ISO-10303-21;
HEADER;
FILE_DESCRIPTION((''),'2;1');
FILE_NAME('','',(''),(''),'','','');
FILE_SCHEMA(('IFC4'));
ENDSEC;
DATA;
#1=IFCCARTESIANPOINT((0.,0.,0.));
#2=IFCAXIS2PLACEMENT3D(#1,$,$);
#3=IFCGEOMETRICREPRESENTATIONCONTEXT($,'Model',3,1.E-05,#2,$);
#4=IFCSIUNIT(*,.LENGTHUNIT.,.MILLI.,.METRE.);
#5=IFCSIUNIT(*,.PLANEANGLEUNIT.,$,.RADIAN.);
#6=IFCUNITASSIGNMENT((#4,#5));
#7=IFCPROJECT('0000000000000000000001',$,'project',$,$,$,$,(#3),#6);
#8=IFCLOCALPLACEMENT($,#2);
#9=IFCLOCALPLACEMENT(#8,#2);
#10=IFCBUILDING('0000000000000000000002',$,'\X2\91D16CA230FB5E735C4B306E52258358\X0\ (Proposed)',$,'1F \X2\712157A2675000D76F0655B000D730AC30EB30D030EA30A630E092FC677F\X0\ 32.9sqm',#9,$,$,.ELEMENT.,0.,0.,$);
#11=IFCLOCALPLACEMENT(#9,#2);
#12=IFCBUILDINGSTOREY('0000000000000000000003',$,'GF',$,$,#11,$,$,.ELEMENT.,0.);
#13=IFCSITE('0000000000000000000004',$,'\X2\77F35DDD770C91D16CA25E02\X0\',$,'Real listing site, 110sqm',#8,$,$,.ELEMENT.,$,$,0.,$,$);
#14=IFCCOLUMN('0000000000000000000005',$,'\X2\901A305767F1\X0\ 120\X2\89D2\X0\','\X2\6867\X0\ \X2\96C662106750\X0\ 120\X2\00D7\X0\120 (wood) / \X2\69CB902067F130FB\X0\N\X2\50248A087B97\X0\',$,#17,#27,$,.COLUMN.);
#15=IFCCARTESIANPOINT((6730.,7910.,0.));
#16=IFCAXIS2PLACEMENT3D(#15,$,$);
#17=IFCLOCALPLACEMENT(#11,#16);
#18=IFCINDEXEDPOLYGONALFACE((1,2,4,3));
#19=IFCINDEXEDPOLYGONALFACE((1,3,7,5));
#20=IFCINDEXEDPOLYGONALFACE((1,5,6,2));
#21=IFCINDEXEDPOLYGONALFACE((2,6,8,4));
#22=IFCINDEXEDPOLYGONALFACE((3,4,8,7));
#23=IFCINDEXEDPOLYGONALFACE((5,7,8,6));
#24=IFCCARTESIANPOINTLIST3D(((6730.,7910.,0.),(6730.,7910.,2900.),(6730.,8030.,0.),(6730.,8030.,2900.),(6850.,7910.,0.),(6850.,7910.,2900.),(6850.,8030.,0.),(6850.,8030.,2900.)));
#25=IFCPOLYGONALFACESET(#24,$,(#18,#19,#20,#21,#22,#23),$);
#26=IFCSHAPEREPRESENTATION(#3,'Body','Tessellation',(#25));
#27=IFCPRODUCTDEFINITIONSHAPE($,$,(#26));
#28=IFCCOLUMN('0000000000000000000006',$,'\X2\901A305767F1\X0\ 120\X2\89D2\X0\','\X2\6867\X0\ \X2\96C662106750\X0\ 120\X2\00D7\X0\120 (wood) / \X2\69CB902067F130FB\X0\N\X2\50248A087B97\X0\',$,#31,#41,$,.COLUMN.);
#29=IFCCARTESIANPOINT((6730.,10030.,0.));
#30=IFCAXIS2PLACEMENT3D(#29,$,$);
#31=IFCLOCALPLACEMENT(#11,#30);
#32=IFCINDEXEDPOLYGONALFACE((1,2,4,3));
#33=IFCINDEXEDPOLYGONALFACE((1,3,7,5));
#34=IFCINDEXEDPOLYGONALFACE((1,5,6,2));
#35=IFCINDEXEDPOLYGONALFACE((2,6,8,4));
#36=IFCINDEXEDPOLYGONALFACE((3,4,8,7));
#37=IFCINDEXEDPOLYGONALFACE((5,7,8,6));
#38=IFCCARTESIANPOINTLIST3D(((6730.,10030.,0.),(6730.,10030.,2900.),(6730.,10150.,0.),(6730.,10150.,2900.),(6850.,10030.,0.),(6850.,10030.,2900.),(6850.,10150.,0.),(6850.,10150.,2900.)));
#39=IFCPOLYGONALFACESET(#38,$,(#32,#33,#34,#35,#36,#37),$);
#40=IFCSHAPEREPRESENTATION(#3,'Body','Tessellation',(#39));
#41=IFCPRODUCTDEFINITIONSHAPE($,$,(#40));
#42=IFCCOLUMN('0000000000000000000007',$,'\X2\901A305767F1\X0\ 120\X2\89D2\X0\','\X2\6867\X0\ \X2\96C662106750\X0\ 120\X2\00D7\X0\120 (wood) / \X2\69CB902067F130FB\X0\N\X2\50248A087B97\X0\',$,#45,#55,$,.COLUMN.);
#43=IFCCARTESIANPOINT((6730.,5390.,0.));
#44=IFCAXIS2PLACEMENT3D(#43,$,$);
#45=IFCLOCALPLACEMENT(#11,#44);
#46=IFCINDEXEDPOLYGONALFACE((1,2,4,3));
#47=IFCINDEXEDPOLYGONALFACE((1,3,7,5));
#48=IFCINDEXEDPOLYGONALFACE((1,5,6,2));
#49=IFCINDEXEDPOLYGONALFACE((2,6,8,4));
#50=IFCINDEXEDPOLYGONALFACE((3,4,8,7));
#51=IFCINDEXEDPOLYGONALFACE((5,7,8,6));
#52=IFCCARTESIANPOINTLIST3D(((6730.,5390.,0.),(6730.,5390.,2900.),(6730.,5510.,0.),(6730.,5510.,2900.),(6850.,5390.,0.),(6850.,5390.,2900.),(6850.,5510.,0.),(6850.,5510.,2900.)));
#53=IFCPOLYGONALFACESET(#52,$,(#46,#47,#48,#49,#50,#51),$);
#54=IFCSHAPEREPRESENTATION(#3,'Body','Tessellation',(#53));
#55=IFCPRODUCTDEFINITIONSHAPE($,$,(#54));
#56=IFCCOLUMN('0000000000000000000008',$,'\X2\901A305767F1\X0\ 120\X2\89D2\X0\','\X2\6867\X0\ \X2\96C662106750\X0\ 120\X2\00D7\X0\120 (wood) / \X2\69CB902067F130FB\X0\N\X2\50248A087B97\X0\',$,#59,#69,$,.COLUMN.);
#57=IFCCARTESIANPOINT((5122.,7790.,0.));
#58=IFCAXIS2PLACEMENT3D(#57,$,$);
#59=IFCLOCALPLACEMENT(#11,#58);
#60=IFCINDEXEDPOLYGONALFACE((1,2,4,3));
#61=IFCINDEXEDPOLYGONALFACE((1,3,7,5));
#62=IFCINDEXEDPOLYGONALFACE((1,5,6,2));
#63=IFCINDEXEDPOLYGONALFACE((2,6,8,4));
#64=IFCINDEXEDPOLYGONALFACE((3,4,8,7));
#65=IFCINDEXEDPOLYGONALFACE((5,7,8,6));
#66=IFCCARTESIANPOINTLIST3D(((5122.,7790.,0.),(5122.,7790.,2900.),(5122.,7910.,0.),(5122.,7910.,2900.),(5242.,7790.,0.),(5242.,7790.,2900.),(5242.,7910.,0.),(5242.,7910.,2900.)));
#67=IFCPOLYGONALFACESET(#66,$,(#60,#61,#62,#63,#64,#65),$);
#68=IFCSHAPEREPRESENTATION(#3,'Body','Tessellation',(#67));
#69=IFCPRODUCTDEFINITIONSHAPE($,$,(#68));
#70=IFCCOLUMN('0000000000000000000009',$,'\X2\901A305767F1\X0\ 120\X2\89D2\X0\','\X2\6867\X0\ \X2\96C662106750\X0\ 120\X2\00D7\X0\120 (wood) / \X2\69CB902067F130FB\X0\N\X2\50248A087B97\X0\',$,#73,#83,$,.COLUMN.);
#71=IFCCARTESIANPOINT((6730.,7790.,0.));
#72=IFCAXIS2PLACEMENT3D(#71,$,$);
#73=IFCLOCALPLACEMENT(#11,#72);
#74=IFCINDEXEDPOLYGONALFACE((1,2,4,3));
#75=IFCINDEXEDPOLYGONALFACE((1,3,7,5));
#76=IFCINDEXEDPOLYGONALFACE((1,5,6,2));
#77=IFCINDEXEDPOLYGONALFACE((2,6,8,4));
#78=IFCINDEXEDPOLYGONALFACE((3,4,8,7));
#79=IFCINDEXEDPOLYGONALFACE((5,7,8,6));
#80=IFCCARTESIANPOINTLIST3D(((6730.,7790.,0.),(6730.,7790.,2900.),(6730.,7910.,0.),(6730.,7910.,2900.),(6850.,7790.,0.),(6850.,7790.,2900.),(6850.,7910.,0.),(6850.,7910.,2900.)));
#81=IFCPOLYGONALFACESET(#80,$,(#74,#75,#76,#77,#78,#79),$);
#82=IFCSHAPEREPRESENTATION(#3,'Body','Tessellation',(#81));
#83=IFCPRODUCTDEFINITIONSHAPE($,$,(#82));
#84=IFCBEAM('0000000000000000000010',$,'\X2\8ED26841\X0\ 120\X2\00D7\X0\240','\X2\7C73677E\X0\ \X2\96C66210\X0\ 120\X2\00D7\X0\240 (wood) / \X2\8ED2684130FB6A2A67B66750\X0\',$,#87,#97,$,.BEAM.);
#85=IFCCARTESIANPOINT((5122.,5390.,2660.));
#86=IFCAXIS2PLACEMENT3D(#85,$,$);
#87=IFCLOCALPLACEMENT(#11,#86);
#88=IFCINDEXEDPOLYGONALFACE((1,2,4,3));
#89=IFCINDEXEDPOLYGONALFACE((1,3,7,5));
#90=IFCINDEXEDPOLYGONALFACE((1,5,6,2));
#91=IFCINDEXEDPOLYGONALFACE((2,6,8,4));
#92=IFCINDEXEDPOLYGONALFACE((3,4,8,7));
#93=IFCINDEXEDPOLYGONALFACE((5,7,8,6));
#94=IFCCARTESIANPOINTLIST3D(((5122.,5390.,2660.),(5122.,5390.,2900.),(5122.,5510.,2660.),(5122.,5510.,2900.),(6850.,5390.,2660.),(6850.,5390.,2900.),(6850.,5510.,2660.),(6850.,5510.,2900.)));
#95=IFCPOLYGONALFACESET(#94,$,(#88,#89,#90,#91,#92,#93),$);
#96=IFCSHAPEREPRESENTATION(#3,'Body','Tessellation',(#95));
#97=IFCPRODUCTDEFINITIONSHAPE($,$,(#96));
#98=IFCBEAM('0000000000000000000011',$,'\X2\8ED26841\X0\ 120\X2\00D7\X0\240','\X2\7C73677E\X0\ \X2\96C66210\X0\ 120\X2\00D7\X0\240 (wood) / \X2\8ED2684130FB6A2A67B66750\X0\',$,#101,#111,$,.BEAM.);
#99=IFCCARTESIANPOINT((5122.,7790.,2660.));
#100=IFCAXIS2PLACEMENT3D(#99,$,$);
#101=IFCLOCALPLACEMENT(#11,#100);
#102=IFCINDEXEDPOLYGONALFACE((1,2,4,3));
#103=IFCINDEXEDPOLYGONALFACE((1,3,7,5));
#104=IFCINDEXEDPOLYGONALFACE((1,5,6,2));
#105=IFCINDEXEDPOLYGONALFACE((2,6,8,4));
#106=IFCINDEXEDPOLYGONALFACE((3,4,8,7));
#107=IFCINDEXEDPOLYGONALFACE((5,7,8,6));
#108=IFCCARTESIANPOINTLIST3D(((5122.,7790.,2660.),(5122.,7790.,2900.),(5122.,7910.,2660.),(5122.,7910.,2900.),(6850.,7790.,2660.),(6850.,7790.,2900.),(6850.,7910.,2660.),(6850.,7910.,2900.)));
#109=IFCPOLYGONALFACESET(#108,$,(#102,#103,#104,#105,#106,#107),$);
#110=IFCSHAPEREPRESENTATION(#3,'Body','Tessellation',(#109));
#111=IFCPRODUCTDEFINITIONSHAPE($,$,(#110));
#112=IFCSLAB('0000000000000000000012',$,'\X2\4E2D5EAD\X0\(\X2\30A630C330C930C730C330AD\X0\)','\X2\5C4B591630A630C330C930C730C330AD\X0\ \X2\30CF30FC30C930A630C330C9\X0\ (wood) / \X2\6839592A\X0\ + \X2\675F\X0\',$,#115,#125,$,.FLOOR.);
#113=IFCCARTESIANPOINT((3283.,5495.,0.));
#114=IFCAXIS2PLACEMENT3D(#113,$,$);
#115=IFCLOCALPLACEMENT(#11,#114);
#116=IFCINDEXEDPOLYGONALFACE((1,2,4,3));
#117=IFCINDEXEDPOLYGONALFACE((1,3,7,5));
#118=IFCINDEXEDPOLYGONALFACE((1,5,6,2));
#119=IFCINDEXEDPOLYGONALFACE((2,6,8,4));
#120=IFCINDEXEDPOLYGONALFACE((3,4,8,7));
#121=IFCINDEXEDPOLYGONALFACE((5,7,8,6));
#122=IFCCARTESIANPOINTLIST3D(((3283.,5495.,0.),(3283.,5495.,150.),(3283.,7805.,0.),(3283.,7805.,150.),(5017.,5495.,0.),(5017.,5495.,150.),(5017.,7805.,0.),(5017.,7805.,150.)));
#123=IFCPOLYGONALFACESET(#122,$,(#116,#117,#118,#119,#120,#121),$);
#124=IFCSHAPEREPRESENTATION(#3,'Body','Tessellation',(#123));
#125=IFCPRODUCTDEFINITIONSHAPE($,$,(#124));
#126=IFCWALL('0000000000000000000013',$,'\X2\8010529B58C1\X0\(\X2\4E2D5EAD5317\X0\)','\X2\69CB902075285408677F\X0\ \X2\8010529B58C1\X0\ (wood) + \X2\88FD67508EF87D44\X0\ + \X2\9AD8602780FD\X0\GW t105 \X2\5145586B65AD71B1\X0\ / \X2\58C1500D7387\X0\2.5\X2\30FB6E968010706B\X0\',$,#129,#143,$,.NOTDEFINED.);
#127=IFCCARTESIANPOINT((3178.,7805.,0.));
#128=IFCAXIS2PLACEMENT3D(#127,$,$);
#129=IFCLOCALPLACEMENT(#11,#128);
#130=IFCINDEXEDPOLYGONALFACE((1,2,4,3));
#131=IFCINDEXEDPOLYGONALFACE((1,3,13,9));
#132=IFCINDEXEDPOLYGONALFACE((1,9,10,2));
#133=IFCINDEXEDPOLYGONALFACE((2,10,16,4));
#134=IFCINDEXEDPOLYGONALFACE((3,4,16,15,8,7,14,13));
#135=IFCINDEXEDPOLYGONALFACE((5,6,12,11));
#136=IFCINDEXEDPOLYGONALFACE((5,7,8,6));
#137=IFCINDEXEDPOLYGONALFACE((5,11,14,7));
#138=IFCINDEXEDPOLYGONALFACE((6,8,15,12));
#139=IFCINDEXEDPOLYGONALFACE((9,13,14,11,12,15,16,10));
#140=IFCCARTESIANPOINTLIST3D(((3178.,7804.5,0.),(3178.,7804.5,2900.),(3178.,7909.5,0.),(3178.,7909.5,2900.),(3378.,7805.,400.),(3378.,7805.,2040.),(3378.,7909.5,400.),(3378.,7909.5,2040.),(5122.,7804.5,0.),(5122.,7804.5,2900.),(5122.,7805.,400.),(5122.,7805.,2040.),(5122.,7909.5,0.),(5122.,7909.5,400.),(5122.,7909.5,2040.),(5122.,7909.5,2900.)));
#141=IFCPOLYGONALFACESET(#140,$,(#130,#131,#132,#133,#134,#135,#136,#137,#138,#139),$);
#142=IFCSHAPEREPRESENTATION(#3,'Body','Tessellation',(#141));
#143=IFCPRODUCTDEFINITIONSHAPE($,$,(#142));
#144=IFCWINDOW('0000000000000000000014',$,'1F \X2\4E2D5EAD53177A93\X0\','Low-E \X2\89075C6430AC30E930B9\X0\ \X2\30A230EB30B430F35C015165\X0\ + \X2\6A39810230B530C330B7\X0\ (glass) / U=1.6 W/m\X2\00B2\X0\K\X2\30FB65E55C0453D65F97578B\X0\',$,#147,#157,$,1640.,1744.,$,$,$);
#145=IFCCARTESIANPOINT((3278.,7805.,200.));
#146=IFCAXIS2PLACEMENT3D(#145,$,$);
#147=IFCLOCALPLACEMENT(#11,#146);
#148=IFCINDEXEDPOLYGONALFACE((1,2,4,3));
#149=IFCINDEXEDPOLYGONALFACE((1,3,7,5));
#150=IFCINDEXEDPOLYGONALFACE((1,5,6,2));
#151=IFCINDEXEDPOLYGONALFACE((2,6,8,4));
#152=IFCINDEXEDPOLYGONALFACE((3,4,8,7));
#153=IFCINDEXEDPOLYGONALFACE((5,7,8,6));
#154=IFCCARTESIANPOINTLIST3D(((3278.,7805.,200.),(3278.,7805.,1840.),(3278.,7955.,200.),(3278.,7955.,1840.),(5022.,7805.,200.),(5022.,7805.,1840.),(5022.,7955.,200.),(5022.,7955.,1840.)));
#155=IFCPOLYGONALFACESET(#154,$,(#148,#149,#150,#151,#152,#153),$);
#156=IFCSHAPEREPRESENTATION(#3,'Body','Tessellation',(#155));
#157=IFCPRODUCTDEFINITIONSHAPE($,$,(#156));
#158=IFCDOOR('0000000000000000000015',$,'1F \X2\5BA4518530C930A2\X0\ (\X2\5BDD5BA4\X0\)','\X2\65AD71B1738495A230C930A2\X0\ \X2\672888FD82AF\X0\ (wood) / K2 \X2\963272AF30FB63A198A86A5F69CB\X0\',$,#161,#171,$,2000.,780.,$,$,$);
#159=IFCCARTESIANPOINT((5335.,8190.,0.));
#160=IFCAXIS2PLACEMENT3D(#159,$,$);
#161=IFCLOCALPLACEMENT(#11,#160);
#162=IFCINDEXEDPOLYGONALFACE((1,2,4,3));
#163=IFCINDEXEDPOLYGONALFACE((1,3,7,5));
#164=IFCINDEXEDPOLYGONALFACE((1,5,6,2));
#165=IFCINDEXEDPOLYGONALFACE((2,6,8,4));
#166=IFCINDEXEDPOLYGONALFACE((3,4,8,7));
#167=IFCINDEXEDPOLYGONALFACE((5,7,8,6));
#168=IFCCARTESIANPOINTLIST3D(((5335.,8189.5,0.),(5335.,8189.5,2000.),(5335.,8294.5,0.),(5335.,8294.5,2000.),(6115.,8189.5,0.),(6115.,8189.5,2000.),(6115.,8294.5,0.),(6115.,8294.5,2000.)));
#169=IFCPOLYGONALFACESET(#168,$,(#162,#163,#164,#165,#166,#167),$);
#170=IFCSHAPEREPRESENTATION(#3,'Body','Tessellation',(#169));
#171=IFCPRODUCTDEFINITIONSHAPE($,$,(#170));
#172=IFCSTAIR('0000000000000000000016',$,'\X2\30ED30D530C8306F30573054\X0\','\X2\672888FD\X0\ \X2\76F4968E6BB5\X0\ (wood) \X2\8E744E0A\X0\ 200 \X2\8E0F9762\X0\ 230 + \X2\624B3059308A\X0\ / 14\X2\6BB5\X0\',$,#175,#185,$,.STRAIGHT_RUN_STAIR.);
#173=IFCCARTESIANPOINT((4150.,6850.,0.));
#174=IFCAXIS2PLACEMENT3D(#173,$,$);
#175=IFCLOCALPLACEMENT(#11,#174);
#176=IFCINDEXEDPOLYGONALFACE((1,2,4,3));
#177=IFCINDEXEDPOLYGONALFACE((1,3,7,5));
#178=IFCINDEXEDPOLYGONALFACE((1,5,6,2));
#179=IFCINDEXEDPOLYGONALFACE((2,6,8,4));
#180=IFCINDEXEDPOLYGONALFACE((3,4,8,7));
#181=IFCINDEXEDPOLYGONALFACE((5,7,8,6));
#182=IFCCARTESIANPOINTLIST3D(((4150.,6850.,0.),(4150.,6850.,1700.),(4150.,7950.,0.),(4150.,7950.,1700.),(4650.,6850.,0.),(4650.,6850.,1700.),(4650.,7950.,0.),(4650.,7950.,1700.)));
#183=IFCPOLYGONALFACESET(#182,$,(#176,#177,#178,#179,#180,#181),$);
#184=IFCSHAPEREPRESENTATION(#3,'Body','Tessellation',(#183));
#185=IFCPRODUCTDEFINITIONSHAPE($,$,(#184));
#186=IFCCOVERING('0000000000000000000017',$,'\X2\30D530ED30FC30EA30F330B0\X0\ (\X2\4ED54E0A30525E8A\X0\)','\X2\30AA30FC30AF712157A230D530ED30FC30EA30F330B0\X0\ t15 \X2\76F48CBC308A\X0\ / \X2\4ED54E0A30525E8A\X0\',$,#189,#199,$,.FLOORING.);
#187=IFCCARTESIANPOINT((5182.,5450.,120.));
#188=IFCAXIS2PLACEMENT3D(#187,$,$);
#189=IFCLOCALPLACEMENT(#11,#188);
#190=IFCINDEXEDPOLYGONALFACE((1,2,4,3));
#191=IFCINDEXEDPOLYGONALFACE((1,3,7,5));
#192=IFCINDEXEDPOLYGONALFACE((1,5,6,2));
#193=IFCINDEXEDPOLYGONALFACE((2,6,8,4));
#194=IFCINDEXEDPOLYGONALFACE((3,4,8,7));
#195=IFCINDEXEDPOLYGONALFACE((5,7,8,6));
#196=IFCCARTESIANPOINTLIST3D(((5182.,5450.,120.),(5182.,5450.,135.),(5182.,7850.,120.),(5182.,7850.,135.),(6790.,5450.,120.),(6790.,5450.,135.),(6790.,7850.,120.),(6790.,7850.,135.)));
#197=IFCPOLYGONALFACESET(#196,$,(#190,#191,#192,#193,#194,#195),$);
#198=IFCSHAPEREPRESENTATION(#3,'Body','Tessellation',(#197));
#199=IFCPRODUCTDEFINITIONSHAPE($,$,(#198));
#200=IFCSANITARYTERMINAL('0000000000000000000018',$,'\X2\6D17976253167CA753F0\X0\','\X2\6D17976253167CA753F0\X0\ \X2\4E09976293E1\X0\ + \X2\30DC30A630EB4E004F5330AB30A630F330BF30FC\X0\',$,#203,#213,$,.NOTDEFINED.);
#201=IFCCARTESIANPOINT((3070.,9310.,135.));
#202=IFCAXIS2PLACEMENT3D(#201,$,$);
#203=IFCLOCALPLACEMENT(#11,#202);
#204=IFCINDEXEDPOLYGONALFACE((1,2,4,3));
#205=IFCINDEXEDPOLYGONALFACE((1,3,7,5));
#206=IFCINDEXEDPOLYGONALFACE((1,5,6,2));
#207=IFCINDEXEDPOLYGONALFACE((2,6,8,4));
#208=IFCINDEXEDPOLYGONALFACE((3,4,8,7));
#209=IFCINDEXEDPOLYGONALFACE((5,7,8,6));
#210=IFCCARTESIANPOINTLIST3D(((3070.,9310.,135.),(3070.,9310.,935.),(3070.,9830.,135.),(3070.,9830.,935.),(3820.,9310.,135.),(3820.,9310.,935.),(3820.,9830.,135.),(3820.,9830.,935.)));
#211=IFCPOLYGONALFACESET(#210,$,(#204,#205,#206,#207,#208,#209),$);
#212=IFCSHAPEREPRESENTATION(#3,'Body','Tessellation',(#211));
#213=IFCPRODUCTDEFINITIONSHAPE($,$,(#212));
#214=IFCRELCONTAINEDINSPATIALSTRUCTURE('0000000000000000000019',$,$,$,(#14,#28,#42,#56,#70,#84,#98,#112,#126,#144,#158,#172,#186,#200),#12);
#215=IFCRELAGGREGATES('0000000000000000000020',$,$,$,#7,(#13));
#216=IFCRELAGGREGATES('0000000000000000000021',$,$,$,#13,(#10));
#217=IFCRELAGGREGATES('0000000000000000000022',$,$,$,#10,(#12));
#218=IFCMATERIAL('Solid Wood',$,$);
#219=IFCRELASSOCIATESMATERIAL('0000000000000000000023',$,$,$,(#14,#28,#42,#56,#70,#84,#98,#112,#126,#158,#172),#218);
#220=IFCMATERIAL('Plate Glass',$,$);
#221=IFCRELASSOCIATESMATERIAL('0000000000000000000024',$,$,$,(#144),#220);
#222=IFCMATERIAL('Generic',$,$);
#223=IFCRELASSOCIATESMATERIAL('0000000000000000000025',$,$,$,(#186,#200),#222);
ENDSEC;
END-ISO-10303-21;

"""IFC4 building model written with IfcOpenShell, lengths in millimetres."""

from ifc_helpers import new_model, si_unit, frame, frame_2d, origin, place, context, project, spatial, rectangle, extrude, material, element, fill, save


model = new_model("IFC4")

# Units and contexts
model_context = context("Model", 3, precision=1e-05, world=origin())
ifc_project = project(units=[si_unit("LENGTHUNIT", "METRE", prefix="MILLI"), si_unit("PLANEANGLEUNIT", "RADIAN")], contexts=[model_context])

# Site, building, storey
site_placement = place(None, origin())
site = spatial("IfcSite", under=ifc_project, at=site_placement, Name="石川県金沢市", ObjectType="Real listing site, 110sqm", CompositionType="ELEMENT", RefElevation=0.0)
building_placement = place(site_placement, origin())
building = spatial("IfcBuilding", under=site, at=building_placement, Name="金沢・平屋の別荘 (Proposed)", ObjectType="1F 無垢材×漆喰×ガルバリウム鋼板 32.9sqm", CompositionType="ELEMENT", ElevationOfRefHeight=0.0, ElevationOfTerrain=0.0)
storey_placement = place(building_placement, origin())
storey = spatial("IfcBuildingStorey", under=building, at=storey_placement, Name="GF", CompositionType="ELEMENT", Elevation=0.0)

# Columns
ifc_material_1 = material(Name="Solid Wood")
column_1_placement = place(storey_placement, frame((6730.0, 7910.0, 0.0)))
element("IfcColumn", 1, at=column_1_placement, inside=storey, material=ifc_material_1, Name="通し柱 120角", Description="桧 集成材 120×120 (wood) / 構造柱・N値計算", PredefinedType="COLUMN", context=model_context, shape_type="SweptSolid", body=[
    extrude(rectangle(XDim=120.0, YDim=120.0, at=frame_2d((60.0, 60.0))), frame((6730.0, 7910.0, 0.0)), (0.0, 0.0, 1.0), 2900.0),
])
column_2_placement = place(storey_placement, frame((6730.0, 10030.0, 0.0)))
element("IfcColumn", 2, at=column_2_placement, inside=storey, material=ifc_material_1, Name="通し柱 120角", Description="桧 集成材 120×120 (wood) / 構造柱・N値計算", PredefinedType="COLUMN", context=model_context, shape_type="SweptSolid", body=[
    extrude(rectangle(XDim=120.0, YDim=120.0, at=frame_2d((60.0, 60.0))), frame((6730.0, 10030.0, 0.0)), (0.0, 0.0, 1.0), 2900.0),
])
column_3_placement = place(storey_placement, frame((6730.0, 5390.0, 0.0)))
element("IfcColumn", 3, at=column_3_placement, inside=storey, material=ifc_material_1, Name="通し柱 120角", Description="桧 集成材 120×120 (wood) / 構造柱・N値計算", PredefinedType="COLUMN", context=model_context, shape_type="SweptSolid", body=[
    extrude(rectangle(XDim=120.0, YDim=120.0, at=frame_2d((60.0, 60.0))), frame((6730.0, 5390.0, 0.0)), (0.0, 0.0, 1.0), 2900.0),
])
column_4_placement = place(storey_placement, frame((5122.0, 7790.0, 0.0)))
element("IfcColumn", 4, at=column_4_placement, inside=storey, material=ifc_material_1, Name="通し柱 120角", Description="桧 集成材 120×120 (wood) / 構造柱・N値計算", PredefinedType="COLUMN", context=model_context, shape_type="SweptSolid", body=[
    extrude(rectangle(XDim=120.0, YDim=120.0, at=frame_2d((60.0, 60.0))), frame((5122.0, 7790.0, 0.0)), (0.0, 0.0, 1.0), 2900.0),
])
column_5_placement = place(storey_placement, frame((6730.0, 7790.0, 0.0)))
element("IfcColumn", 5, at=column_5_placement, inside=storey, material=ifc_material_1, Name="通し柱 120角", Description="桧 集成材 120×120 (wood) / 構造柱・N値計算", PredefinedType="COLUMN", context=model_context, shape_type="SweptSolid", body=[
    extrude(rectangle(XDim=120.0, YDim=120.0, at=frame_2d((60.0, 60.0))), frame((6730.0, 7790.0, 0.0)), (0.0, 0.0, 1.0), 2900.0),
])

# Beams
beam_1_placement = place(storey_placement, frame((5122.0, 5390.0, 2660.0)))
element("IfcBeam", 6, at=beam_1_placement, inside=storey, material=ifc_material_1, Name="軒桁 120×240", Description="米松 集成 120×240 (wood) / 軒桁・横架材", PredefinedType="BEAM", context=model_context, shape_type="SweptSolid", body=[
    extrude(rectangle(XDim=1728.0, YDim=120.0, at=frame_2d((864.0, 60.0))), frame((5122.0, 5390.0, 2660.0)), (0.0, 0.0, 1.0), 240.0),
])
beam_2_placement = place(storey_placement, frame((5122.0, 7790.0, 2660.0)))
element("IfcBeam", 7, at=beam_2_placement, inside=storey, material=ifc_material_1, Name="軒桁 120×240", Description="米松 集成 120×240 (wood) / 軒桁・横架材", PredefinedType="BEAM", context=model_context, shape_type="SweptSolid", body=[
    extrude(rectangle(XDim=1728.0, YDim=120.0, at=frame_2d((864.0, 60.0))), frame((5122.0, 7790.0, 2660.0)), (0.0, 0.0, 1.0), 240.0),
])

# Slab
slab_placement = place(storey_placement, frame((3283.0, 5495.0, 0.0)))
element("IfcSlab", 8, at=slab_placement, inside=storey, material=ifc_material_1, Name="中庭(ウッドデッキ)", Description="屋外ウッドデッキ ハードウッド (wood) / 根太 + 束", PredefinedType="FLOOR", context=model_context, shape_type="SweptSolid", body=[
    extrude(rectangle(XDim=1734.0, YDim=2310.0, at=frame_2d((867.0, 1155.0))), frame((3283.0, 5495.0, 0.0)), (0.0, 0.0, 1.0), 150.0),
])

# Wall, opening, window
wall_1_placement = place(storey_placement, frame((3178.0, 7805.0, 0.0)))
wall_1 = element("IfcWall", 9, at=wall_1_placement, inside=storey, material=ifc_material_1, Name="耐力壁(中庭北)", Description="構造用合板 耐力壁 (wood) + 製材軸組 + 高性能GW t105 充填断熱 / 壁倍率2.5・準耐火", PredefinedType="NOTDEFINED", context=model_context, shape_type="SweptSolid", body=[
    extrude(rectangle(XDim=1944.0, YDim=105.0, at=frame_2d((972.0, 52.0))), frame((3178.0, 7805.0, 0.0)), (0.0, 0.0, 1.0), 2900.0),
])
opening_placement = place(storey_placement, frame((3278.0, 7805.0, 200.0)))
opening = element("IfcOpeningElement", 10, at=opening_placement, cuts=wall_1, PredefinedType="NOTDEFINED", context=model_context, shape_type="SweptSolid", body=[
    extrude(rectangle(XDim=1744.0, YDim=150.0, at=frame_2d((872.0, 75.0))), frame((3278.0, 7805.0, 200.0)), (0.0, 0.0, 1.0), 1640.0),
])
ifc_material_2 = material(Name="Plate Glass")
window_placement = place(storey_placement, frame((3278.0, 7805.0, 200.0)))
window = element("IfcWindow", 11, at=window_placement, inside=storey, material=ifc_material_2, Name="1F 中庭北窓", Description="Low-E 複層ガラス アルゴン封入 + 樹脂サッシ (glass) / U=1.6 W/m²K・日射取得型", OverallHeight=1640.0, OverallWidth=1744.0, context=model_context, shape_type="SweptSolid", body=[
    extrude(rectangle(XDim=1744.0, YDim=150.0, at=frame_2d((872.0, 75.0))), frame((3278.0, 7805.0, 200.0)), (0.0, 0.0, 1.0), 1640.0),
])
fill(opening, window)

# Door
door_placement = place(storey_placement, frame((5335.0, 8190.0, 0.0)))
element("IfcDoor", 12, at=door_placement, inside=storey, material=ifc_material_1, Name="1F 室内ドア (寝室)", Description="断熱玄関ドア 木製芯 (wood) / K2 防犯・採風機構", OverallHeight=2000.0, OverallWidth=780.0, context=model_context, shape_type="SweptSolid", body=[
    extrude(rectangle(XDim=780.0, YDim=105.0, at=frame_2d((390.0, 52.0))), frame((5335.0, 8190.0, 0.0)), (0.0, 0.0, 1.0), 2000.0),
])

# Stair
stair_placement = place(storey_placement, frame((4150.0, 6850.0, 0.0)))
element("IfcStair", 13, at=stair_placement, inside=storey, material=ifc_material_1, Name="ロフトはしご", Description="木製 直階段 (wood) 蹴上 200 踏面 230 + 手すり / 14段", PredefinedType="STRAIGHT_RUN_STAIR", context=model_context, shape_type="SweptSolid", body=[
    extrude(rectangle(XDim=500.0, YDim=1100.0, at=frame_2d((250.0, 550.0))), frame((4150.0, 6850.0, 0.0)), (0.0, 0.0, 1.0), 1700.0),
])

# Covering
ifc_material_3 = material(Name="Generic")
covering_placement = place(storey_placement, frame((5182.0, 5450.0, 120.0)))
element("IfcCovering", 14, at=covering_placement, inside=storey, material=ifc_material_3, Name="フローリング (仕上げ床)", Description="オーク無垢フローリング t15 直貼り / 仕上げ床", PredefinedType="FLOORING", context=model_context, shape_type="SweptSolid", body=[
    extrude(rectangle(XDim=1608.0, YDim=2400.0, at=frame_2d((804.0, 1200.0))), frame((5182.0, 5450.0, 120.0)), (0.0, 0.0, 1.0), 15.0),
])

# Sanitary terminal
sanitary_terminal_1_placement = place(storey_placement, frame((3070.0, 9310.0, 135.0)))
element("IfcSanitaryTerminal", 15, at=sanitary_terminal_1_placement, inside=storey, material=ifc_material_3, Name="洗面化粧台", Description="洗面化粧台 三面鏡 + ボウル一体カウンター", PredefinedType="NOTDEFINED", context=model_context, shape_type="SweptSolid", body=[
    extrude(rectangle(XDim=750.0, YDim=520.0, at=frame_2d((375.0, 260.0))), frame((3070.0, 9310.0, 135.0)), (0.0, 0.0, 1.0), 800.0),
])

save(model, "model.ifc")
